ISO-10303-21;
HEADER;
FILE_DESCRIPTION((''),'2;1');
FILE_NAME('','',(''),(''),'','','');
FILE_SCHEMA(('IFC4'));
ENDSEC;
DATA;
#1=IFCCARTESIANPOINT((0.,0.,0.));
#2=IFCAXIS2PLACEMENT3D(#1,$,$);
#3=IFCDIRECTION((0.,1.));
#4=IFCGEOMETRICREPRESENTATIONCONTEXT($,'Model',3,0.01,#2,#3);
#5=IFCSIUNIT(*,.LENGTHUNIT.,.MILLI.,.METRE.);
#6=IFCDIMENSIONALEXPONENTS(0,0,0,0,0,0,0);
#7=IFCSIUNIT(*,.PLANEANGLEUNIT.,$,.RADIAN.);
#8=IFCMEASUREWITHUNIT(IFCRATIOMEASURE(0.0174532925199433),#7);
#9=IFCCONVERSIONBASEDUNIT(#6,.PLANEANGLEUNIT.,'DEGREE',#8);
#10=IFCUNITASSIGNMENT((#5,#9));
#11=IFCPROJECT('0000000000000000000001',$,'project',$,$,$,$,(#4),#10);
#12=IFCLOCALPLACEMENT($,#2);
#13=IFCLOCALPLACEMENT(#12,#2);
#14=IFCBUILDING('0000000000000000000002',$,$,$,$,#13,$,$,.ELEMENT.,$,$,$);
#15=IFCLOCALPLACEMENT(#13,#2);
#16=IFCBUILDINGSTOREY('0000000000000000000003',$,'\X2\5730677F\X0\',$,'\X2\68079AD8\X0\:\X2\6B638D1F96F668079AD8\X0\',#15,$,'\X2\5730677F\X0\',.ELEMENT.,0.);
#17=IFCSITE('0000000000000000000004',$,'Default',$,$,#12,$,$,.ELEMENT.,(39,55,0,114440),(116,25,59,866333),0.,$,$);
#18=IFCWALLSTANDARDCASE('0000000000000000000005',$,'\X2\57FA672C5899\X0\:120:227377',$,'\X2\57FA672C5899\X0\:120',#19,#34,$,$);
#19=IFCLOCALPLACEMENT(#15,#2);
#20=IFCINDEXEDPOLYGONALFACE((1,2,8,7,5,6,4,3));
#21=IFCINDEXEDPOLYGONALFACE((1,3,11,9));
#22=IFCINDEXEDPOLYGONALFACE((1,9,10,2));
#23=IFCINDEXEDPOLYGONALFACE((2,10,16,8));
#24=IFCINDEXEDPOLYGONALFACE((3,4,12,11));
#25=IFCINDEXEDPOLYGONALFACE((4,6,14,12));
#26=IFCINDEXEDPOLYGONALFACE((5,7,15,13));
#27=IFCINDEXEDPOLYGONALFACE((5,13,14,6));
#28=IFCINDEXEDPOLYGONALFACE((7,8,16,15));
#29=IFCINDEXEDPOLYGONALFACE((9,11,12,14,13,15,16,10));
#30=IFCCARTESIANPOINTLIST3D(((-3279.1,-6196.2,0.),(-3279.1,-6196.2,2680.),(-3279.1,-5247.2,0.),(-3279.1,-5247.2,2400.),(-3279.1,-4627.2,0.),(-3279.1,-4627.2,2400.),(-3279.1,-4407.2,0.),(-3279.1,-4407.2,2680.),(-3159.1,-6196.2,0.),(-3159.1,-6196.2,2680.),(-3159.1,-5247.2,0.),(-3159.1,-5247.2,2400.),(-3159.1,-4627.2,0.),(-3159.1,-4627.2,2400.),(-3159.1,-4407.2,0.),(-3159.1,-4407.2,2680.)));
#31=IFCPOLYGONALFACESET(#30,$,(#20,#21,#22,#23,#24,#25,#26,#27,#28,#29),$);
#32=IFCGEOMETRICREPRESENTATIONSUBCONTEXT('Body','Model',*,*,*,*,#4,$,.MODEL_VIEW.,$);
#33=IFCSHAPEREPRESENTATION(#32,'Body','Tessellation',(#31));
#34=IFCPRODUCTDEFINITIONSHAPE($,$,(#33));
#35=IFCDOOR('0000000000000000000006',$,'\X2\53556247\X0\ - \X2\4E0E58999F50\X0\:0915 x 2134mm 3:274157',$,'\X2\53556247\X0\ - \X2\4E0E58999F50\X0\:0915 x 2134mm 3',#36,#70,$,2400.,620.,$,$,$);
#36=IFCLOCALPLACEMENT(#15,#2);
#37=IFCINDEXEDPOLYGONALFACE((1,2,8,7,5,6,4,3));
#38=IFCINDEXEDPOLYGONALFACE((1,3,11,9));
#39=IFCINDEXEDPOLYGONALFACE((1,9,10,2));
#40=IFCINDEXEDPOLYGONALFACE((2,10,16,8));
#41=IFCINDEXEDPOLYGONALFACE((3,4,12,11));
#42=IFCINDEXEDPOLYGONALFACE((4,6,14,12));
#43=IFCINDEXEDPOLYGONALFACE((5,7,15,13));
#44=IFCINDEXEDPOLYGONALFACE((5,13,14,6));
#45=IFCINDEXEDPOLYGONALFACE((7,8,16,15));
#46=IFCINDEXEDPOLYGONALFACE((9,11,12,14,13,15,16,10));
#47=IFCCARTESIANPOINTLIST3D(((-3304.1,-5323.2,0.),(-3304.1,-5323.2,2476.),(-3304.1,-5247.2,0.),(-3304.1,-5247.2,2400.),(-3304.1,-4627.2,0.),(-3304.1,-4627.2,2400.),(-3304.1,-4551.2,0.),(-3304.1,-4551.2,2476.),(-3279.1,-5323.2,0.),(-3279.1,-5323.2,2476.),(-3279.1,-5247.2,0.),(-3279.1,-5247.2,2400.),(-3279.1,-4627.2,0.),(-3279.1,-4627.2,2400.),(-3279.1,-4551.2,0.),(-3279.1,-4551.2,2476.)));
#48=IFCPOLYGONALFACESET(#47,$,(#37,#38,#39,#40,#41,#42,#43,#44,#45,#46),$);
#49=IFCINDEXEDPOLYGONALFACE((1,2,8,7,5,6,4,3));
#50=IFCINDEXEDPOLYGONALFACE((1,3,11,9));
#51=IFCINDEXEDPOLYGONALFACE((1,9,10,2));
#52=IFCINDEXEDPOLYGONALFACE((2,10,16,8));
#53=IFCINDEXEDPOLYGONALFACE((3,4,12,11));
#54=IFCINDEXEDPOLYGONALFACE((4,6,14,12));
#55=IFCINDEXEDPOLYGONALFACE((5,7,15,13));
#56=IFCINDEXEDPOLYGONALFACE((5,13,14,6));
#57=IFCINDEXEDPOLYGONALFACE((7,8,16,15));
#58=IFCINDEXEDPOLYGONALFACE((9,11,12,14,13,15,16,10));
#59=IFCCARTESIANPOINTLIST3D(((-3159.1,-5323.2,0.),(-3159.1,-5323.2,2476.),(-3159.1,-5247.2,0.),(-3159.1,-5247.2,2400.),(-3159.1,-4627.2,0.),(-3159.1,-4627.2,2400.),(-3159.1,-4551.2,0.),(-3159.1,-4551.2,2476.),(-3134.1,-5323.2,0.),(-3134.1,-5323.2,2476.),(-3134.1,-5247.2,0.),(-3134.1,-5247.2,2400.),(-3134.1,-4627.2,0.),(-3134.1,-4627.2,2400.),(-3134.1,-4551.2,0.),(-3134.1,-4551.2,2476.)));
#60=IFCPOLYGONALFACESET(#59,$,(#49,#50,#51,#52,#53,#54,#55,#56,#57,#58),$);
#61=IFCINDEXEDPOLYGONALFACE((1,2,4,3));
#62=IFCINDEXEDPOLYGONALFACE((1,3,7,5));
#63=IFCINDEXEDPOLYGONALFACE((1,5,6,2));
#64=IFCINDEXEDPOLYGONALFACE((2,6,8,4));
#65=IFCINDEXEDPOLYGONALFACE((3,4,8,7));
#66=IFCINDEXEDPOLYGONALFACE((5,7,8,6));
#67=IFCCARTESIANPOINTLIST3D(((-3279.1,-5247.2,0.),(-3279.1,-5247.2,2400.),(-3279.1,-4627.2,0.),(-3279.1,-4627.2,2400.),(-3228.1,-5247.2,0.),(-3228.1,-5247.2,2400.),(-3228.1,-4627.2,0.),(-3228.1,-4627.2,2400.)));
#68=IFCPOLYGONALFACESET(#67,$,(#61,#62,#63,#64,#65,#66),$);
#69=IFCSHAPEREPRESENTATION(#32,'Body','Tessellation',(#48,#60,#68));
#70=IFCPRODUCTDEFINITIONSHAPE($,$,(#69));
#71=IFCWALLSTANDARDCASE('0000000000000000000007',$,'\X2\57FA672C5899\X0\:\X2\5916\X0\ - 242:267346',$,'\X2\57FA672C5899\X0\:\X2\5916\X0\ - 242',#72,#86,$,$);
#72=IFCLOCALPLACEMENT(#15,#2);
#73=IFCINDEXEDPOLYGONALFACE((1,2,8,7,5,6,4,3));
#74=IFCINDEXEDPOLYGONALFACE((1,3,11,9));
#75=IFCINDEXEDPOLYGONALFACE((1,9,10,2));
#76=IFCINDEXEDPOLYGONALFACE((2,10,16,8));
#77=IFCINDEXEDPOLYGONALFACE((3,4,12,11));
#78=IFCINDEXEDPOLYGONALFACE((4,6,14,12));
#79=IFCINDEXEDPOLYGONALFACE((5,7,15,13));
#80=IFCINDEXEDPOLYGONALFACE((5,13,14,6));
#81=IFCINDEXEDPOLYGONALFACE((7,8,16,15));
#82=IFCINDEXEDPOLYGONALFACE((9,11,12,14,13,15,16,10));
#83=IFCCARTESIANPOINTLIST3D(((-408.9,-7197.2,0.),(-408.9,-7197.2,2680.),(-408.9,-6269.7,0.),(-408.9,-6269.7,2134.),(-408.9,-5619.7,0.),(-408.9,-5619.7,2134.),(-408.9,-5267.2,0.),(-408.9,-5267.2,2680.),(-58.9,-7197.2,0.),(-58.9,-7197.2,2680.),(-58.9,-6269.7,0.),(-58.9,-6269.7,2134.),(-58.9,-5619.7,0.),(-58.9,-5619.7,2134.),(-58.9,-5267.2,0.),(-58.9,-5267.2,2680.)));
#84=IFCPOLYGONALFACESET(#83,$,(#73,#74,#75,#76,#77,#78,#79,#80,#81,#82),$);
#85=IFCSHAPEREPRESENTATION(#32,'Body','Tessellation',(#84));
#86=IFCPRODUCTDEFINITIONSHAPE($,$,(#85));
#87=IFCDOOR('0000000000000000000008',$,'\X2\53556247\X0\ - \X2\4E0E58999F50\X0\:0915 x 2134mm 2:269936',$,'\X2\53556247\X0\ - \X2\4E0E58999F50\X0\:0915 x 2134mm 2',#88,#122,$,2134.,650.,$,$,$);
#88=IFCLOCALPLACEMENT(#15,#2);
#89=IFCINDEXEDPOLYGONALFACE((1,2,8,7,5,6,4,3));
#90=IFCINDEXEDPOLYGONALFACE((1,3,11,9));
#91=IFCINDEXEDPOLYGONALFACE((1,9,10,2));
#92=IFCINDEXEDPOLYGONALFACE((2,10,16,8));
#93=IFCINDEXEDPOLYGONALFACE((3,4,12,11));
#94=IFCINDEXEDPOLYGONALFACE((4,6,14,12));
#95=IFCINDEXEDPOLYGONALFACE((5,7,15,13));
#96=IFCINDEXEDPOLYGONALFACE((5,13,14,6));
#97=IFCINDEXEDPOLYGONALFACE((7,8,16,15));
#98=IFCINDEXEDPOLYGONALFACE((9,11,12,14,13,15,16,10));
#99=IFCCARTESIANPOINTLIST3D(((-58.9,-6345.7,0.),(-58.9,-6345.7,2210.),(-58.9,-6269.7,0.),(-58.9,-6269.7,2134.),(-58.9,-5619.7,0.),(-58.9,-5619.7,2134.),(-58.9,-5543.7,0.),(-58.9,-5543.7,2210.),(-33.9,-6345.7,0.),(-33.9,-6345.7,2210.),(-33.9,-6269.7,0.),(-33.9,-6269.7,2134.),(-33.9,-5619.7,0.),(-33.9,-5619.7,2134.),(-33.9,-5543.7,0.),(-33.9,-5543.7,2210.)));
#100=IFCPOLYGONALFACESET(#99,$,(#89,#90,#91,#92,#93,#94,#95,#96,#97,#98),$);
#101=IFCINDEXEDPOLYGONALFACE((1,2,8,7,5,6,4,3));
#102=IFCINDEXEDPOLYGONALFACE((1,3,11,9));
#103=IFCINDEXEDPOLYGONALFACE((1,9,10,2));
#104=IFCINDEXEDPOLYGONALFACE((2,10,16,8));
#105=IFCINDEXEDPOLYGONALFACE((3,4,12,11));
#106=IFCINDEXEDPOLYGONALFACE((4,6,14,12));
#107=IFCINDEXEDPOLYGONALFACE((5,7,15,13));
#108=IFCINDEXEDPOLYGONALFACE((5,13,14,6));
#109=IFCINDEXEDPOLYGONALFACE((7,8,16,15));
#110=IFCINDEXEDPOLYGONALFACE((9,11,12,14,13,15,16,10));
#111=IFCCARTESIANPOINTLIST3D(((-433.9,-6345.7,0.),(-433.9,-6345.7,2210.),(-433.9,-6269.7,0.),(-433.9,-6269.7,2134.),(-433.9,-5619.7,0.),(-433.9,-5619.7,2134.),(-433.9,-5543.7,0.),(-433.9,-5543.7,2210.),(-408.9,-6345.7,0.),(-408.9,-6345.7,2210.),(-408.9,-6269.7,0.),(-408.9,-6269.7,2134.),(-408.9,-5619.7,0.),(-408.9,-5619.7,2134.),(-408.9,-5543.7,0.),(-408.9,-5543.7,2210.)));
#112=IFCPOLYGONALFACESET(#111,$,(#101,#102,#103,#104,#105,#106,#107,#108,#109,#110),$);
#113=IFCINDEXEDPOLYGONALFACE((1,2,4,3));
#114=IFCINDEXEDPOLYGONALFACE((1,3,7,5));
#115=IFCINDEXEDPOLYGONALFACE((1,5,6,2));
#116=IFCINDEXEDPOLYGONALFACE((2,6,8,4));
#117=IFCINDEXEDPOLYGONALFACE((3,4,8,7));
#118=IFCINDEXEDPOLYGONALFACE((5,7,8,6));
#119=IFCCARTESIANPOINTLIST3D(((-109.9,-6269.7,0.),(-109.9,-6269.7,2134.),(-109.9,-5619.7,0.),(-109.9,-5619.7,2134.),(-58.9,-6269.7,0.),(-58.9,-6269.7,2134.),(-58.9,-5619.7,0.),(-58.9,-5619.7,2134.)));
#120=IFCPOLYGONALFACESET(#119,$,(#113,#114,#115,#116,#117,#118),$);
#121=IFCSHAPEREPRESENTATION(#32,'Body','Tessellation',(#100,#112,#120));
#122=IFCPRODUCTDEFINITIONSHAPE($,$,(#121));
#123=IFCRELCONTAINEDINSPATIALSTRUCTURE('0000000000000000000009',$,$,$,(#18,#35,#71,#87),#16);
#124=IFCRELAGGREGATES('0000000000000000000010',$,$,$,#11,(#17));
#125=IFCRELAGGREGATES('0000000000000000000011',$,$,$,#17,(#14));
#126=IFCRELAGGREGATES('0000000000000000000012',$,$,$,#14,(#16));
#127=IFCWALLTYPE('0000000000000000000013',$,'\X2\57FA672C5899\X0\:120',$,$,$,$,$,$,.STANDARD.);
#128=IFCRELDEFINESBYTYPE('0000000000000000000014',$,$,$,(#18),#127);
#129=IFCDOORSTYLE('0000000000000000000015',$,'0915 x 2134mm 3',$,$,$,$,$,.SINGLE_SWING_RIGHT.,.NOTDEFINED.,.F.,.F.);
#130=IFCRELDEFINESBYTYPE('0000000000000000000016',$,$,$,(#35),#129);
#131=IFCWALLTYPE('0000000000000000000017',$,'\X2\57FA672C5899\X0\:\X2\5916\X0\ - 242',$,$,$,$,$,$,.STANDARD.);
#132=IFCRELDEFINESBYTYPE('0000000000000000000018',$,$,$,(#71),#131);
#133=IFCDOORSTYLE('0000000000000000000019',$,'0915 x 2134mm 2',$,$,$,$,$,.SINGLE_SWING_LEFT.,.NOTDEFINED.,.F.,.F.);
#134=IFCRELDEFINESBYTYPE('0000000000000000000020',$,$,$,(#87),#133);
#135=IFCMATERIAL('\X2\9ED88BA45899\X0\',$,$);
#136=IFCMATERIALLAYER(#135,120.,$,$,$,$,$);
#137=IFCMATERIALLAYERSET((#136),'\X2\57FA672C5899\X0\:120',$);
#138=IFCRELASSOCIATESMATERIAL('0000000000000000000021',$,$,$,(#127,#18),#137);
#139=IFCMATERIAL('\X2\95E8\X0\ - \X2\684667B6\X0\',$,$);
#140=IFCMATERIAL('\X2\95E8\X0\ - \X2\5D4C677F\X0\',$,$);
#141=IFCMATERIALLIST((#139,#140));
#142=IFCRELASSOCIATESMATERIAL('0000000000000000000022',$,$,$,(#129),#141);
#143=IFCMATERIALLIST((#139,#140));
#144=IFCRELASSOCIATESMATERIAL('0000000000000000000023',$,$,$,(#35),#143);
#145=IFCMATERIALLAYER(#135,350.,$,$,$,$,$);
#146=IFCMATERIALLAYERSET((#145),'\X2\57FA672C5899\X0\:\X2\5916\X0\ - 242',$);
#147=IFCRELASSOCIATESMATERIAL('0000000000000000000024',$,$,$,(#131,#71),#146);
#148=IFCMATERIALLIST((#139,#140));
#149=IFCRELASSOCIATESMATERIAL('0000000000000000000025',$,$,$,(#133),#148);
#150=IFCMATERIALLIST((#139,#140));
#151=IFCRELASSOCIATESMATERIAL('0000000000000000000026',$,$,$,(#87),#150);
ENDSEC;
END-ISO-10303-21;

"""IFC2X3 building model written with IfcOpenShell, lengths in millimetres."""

from ifc_helpers import new_model, entity, si_unit, converted_unit, direction, frame, frame_2d, origin, origin_2d_with_axis, place, context, subcontext, project, spatial, polyline, rectangle, outline, extrude, source, transform, mapped, material, material_list, layer, layer_set, layer_usage, type_object, type_shapes, element, fill, save


model = new_model("IFC2X3")

# Units and contexts
model_context = context("Model", 3, precision=0.01, world=origin(), true_north=direction((0.0, 1.0)))
body_context = subcontext(model_context, "Body", "Model", "MODEL_VIEW")
ifc_project = project(units=[si_unit("LENGTHUNIT", "METRE", prefix="MILLI"), converted_unit("PLANEANGLEUNIT", "DEGREE", entity("IfcRatioMeasure", 0.0174532925199433), si_unit("PLANEANGLEUNIT", "RADIAN"), dimensions=[0, 0, 0, 0, 0, 0, 0])], contexts=[model_context])

# Site, building, storey
site_placement = place(None, origin())
site = spatial("IfcSite", under=ifc_project, at=site_placement, Name="Default", CompositionType="ELEMENT", RefLatitude=(39, 55, 0, 114440), RefLongitude=(116, 25, 59, 866333), RefElevation=0.0)
building_placement = place(site_placement, origin())
building = spatial("IfcBuilding", under=site, at=building_placement, CompositionType="ELEMENT")
storey_placement = place(building_placement, origin())
storey = spatial("IfcBuildingStorey", under=building, at=storey_placement, Name="地板", ObjectType="标高:正负零标高", LongName="地板", CompositionType="ELEMENT", Elevation=0.0)

# Shared definitions
ifc_material_1 = material(Name="默认墙")

# Walls, openings, doors
ifc_layer_1 = layer(ifc_material_1, 120.0)
ifc_layer_set_1 = layer_set([ifc_layer_1], Name="基本墙:120")
ifc_layer_usage_1 = layer_usage(ifc_layer_set_1, "AXIS2", "NEGATIVE", 60.0)
wall_type_1 = type_object("IfcWallType", Name="基本墙:120", PredefinedType="STANDARD", material=ifc_layer_set_1)
wall_1_placement = place(storey_placement, frame((-3219.1, -4407.2, 0.0), z_axis=(0.0, 0.0, 1.0), x_axis=(0.0, -1.0, 0.0)))
wall_1 = element("IfcWallStandardCase", 1, at=wall_1_placement, inside=storey, type_object=wall_type_1, material=ifc_layer_usage_1, Name="基本墙:120:227377", ObjectType="基本墙:120", context=body_context, shape_type="SweptSolid", body=[
    extrude(rectangle(XDim=1789.0, YDim=120.0, at=frame_2d((894.5, 0.0), x_axis=(-1.0, 0.0))), origin(), (0.0, 0.0, 1.0), 2680.0),
])
opening_1_placement = place(wall_1_placement, frame((840.0, 60.0, 0.0)))
opening_1 = element("IfcOpeningElement", 2, at=opening_1_placement, cuts=wall_1, ObjectType="Opening", context=body_context, shape_type="SweptSolid", body=[
    extrude(rectangle(XDim=620.0, YDim=2400.0, at=frame_2d((1200.0, 310.0), x_axis=(0.0, 1.0))), frame((0.0, 0.0, 0.0), z_axis=(0.0, -1.0, 0.0), x_axis=(0.0, 0.0, 1.0)), (0.0, 0.0, 1.0), 120.0),
])
ifc_material_2 = material(Name="门 - 框架")
ifc_material_3 = material(Name="门 - 嵌板")
ifc_material_list_1 = material_list([ifc_material_2, ifc_material_3])
ifc_material_list_2 = material_list([ifc_material_2, ifc_material_3])
door_style_1 = type_object("IfcDoorStyle", Name="0915 x 2134mm 3", ConstructionType="NOTDEFINED", OperationType="SINGLE_SWING_RIGHT", ParameterTakesPrecedence=False, Sizeable=False, material=ifc_material_list_2)
shared_shape_1 = source(origin(), body_context, "Body", "SweptSolid", [
    extrude(outline(polyline([(-386.0, -1257.0), (386.0, -1257.0), (386.0, 1219.0), (310.0, 1219.0), (310.0, -1181.0), (-310.0, -1181.0), (-310.0, 1219.0), (-386.0, 1219.0), (-386.0, -1257.0)])), frame((310.0, 120.0, 1219.0), z_axis=(0.0, 1.0, 0.0), x_axis=(1.0, 0.0, 0.0)), (0.0, 0.0, 1.0), 25.0),
    extrude(outline(polyline([(-1257.0, -386.0), (1219.0, -386.0), (1219.0, -310.0), (-1181.0, -310.0), (-1181.0, 310.0), (1219.0, 310.0), (1219.0, 386.0), (-1257.0, 386.0), (-1257.0, -386.0)])), frame((310.0, -25.0, 1219.0), z_axis=(0.0, 1.0, 0.0), x_axis=(0.0, 0.0, -1.0)), (0.0, 0.0, 1.0), 25.0),
    extrude(rectangle(XDim=51.0, YDim=620.0, at=origin_2d_with_axis()), frame((310.0, 94.5, 0.0), z_axis=(0.0, 0.0, 1.0), x_axis=(0.0, 1.0, 0.0)), (0.0, 0.0, 1.0), 2400.0),
])
type_shapes(door_style_1, [shared_shape_1])
door_1_placement = place(opening_1_placement, frame((0.0, 0.0, 0.0), z_axis=(0.0, 0.0, 1.0), x_axis=(-1.0, 0.0, 0.0)))
door_1 = element("IfcDoor", 3, at=door_1_placement, inside=storey, type_object=door_style_1, material=ifc_material_list_1, Name="单扇 - 与墙齐:0915 x 2134mm 3:274157", ObjectType="单扇 - 与墙齐:0915 x 2134mm 3", OverallHeight=2400.0, OverallWidth=620.0, context=body_context, shape_type="MappedRepresentation", body=[
    mapped(shared_shape_1, transform((0.0, 0.0, 0.0), scale=1.0)),
])
fill(opening_1, door_1)
ifc_layer_2 = layer(ifc_material_1, 350.0)
ifc_layer_set_2 = layer_set([ifc_layer_2], Name="基本墙:外 - 242")
ifc_layer_usage_2 = layer_usage(ifc_layer_set_2, "AXIS2", "NEGATIVE", 175.0)
wall_type_2 = type_object("IfcWallType", Name="基本墙:外 - 242", PredefinedType="STANDARD", material=ifc_layer_set_2)
wall_2_placement = place(storey_placement, frame((-233.9, -5267.2, 0.0), z_axis=(0.0, 0.0, 1.0), x_axis=(0.0, -1.0, 0.0)))
wall_2 = element("IfcWallStandardCase", 4, at=wall_2_placement, inside=storey, type_object=wall_type_2, material=ifc_layer_usage_2, Name="基本墙:外 - 242:267346", ObjectType="基本墙:外 - 242", context=body_context, shape_type="SweptSolid", body=[
    extrude(rectangle(XDim=1930.0, YDim=350.0, at=frame_2d((965.0, 0.0), x_axis=(-1.0, 0.0))), origin(), (0.0, 0.0, 1.0), 2680.0),
])
opening_2_placement = place(wall_2_placement, frame((352.5, -175.0, 0.0)))
opening_2 = element("IfcOpeningElement", 5, at=opening_2_placement, cuts=wall_2, ObjectType="Opening", context=body_context, shape_type="SweptSolid", body=[
    extrude(rectangle(XDim=650.0, YDim=2134.0, at=frame_2d((1067.0, 325.0), x_axis=(0.0, -1.0))), frame((0.0, 0.0, 0.0), z_axis=(0.0, 1.0, 0.0), x_axis=(0.0, 0.0, 1.0)), (0.0, 0.0, 1.0), 350.0),
])
ifc_material_list_3 = material_list([ifc_material_2, ifc_material_3])
ifc_material_list_4 = material_list([ifc_material_2, ifc_material_3])
door_style_2 = type_object("IfcDoorStyle", Name="0915 x 2134mm 2", ConstructionType="NOTDEFINED", OperationType="SINGLE_SWING_LEFT", ParameterTakesPrecedence=False, Sizeable=False, material=ifc_material_list_4)
shared_shape_2 = source(origin(), body_context, "Body", "SweptSolid", [
    extrude(outline(polyline([(-401.0, -1124.0), (401.0, -1124.0), (401.0, 1086.0), (325.0, 1086.0), (325.0, -1048.0), (-325.0, -1048.0), (-325.0, 1086.0), (-401.0, 1086.0), (-401.0, -1124.0)])), frame((325.0, 375.0, 1086.0), z_axis=(0.0, -1.0, 0.0), x_axis=(-1.0, 0.0, 0.0)), (0.0, 0.0, 1.0), 25.0),
    extrude(outline(polyline([(-1124.0, -401.0), (1086.0, -401.0), (1086.0, -325.0), (-1048.0, -325.0), (-1048.0, 325.0), (1086.0, 325.0), (1086.0, 401.0), (-1124.0, 401.0), (-1124.0, -401.0)])), frame((325.0, 0.0, 1086.0), z_axis=(0.0, -1.0, 0.0), x_axis=(0.0, 0.0, -1.0)), (0.0, 0.0, 1.0), 25.0),
    extrude(rectangle(XDim=650.0, YDim=51.0, at=origin_2d_with_axis()), frame((325.0, 324.5, 0.0)), (0.0, 0.0, 1.0), 2134.0),
])
type_shapes(door_style_2, [shared_shape_2])
door_2_placement = place(opening_2_placement, origin())
door_2 = element("IfcDoor", 6, at=door_2_placement, inside=storey, type_object=door_style_2, material=ifc_material_list_3, Name="单扇 - 与墙齐:0915 x 2134mm 2:269936", ObjectType="单扇 - 与墙齐:0915 x 2134mm 2", OverallHeight=2134.0, OverallWidth=650.0, context=body_context, shape_type="MappedRepresentation", body=[
    mapped(shared_shape_2, transform((0.0, 0.0, 0.0), scale=1.0)),
])
fill(opening_2, door_2)

save(model, "model.ifc")
